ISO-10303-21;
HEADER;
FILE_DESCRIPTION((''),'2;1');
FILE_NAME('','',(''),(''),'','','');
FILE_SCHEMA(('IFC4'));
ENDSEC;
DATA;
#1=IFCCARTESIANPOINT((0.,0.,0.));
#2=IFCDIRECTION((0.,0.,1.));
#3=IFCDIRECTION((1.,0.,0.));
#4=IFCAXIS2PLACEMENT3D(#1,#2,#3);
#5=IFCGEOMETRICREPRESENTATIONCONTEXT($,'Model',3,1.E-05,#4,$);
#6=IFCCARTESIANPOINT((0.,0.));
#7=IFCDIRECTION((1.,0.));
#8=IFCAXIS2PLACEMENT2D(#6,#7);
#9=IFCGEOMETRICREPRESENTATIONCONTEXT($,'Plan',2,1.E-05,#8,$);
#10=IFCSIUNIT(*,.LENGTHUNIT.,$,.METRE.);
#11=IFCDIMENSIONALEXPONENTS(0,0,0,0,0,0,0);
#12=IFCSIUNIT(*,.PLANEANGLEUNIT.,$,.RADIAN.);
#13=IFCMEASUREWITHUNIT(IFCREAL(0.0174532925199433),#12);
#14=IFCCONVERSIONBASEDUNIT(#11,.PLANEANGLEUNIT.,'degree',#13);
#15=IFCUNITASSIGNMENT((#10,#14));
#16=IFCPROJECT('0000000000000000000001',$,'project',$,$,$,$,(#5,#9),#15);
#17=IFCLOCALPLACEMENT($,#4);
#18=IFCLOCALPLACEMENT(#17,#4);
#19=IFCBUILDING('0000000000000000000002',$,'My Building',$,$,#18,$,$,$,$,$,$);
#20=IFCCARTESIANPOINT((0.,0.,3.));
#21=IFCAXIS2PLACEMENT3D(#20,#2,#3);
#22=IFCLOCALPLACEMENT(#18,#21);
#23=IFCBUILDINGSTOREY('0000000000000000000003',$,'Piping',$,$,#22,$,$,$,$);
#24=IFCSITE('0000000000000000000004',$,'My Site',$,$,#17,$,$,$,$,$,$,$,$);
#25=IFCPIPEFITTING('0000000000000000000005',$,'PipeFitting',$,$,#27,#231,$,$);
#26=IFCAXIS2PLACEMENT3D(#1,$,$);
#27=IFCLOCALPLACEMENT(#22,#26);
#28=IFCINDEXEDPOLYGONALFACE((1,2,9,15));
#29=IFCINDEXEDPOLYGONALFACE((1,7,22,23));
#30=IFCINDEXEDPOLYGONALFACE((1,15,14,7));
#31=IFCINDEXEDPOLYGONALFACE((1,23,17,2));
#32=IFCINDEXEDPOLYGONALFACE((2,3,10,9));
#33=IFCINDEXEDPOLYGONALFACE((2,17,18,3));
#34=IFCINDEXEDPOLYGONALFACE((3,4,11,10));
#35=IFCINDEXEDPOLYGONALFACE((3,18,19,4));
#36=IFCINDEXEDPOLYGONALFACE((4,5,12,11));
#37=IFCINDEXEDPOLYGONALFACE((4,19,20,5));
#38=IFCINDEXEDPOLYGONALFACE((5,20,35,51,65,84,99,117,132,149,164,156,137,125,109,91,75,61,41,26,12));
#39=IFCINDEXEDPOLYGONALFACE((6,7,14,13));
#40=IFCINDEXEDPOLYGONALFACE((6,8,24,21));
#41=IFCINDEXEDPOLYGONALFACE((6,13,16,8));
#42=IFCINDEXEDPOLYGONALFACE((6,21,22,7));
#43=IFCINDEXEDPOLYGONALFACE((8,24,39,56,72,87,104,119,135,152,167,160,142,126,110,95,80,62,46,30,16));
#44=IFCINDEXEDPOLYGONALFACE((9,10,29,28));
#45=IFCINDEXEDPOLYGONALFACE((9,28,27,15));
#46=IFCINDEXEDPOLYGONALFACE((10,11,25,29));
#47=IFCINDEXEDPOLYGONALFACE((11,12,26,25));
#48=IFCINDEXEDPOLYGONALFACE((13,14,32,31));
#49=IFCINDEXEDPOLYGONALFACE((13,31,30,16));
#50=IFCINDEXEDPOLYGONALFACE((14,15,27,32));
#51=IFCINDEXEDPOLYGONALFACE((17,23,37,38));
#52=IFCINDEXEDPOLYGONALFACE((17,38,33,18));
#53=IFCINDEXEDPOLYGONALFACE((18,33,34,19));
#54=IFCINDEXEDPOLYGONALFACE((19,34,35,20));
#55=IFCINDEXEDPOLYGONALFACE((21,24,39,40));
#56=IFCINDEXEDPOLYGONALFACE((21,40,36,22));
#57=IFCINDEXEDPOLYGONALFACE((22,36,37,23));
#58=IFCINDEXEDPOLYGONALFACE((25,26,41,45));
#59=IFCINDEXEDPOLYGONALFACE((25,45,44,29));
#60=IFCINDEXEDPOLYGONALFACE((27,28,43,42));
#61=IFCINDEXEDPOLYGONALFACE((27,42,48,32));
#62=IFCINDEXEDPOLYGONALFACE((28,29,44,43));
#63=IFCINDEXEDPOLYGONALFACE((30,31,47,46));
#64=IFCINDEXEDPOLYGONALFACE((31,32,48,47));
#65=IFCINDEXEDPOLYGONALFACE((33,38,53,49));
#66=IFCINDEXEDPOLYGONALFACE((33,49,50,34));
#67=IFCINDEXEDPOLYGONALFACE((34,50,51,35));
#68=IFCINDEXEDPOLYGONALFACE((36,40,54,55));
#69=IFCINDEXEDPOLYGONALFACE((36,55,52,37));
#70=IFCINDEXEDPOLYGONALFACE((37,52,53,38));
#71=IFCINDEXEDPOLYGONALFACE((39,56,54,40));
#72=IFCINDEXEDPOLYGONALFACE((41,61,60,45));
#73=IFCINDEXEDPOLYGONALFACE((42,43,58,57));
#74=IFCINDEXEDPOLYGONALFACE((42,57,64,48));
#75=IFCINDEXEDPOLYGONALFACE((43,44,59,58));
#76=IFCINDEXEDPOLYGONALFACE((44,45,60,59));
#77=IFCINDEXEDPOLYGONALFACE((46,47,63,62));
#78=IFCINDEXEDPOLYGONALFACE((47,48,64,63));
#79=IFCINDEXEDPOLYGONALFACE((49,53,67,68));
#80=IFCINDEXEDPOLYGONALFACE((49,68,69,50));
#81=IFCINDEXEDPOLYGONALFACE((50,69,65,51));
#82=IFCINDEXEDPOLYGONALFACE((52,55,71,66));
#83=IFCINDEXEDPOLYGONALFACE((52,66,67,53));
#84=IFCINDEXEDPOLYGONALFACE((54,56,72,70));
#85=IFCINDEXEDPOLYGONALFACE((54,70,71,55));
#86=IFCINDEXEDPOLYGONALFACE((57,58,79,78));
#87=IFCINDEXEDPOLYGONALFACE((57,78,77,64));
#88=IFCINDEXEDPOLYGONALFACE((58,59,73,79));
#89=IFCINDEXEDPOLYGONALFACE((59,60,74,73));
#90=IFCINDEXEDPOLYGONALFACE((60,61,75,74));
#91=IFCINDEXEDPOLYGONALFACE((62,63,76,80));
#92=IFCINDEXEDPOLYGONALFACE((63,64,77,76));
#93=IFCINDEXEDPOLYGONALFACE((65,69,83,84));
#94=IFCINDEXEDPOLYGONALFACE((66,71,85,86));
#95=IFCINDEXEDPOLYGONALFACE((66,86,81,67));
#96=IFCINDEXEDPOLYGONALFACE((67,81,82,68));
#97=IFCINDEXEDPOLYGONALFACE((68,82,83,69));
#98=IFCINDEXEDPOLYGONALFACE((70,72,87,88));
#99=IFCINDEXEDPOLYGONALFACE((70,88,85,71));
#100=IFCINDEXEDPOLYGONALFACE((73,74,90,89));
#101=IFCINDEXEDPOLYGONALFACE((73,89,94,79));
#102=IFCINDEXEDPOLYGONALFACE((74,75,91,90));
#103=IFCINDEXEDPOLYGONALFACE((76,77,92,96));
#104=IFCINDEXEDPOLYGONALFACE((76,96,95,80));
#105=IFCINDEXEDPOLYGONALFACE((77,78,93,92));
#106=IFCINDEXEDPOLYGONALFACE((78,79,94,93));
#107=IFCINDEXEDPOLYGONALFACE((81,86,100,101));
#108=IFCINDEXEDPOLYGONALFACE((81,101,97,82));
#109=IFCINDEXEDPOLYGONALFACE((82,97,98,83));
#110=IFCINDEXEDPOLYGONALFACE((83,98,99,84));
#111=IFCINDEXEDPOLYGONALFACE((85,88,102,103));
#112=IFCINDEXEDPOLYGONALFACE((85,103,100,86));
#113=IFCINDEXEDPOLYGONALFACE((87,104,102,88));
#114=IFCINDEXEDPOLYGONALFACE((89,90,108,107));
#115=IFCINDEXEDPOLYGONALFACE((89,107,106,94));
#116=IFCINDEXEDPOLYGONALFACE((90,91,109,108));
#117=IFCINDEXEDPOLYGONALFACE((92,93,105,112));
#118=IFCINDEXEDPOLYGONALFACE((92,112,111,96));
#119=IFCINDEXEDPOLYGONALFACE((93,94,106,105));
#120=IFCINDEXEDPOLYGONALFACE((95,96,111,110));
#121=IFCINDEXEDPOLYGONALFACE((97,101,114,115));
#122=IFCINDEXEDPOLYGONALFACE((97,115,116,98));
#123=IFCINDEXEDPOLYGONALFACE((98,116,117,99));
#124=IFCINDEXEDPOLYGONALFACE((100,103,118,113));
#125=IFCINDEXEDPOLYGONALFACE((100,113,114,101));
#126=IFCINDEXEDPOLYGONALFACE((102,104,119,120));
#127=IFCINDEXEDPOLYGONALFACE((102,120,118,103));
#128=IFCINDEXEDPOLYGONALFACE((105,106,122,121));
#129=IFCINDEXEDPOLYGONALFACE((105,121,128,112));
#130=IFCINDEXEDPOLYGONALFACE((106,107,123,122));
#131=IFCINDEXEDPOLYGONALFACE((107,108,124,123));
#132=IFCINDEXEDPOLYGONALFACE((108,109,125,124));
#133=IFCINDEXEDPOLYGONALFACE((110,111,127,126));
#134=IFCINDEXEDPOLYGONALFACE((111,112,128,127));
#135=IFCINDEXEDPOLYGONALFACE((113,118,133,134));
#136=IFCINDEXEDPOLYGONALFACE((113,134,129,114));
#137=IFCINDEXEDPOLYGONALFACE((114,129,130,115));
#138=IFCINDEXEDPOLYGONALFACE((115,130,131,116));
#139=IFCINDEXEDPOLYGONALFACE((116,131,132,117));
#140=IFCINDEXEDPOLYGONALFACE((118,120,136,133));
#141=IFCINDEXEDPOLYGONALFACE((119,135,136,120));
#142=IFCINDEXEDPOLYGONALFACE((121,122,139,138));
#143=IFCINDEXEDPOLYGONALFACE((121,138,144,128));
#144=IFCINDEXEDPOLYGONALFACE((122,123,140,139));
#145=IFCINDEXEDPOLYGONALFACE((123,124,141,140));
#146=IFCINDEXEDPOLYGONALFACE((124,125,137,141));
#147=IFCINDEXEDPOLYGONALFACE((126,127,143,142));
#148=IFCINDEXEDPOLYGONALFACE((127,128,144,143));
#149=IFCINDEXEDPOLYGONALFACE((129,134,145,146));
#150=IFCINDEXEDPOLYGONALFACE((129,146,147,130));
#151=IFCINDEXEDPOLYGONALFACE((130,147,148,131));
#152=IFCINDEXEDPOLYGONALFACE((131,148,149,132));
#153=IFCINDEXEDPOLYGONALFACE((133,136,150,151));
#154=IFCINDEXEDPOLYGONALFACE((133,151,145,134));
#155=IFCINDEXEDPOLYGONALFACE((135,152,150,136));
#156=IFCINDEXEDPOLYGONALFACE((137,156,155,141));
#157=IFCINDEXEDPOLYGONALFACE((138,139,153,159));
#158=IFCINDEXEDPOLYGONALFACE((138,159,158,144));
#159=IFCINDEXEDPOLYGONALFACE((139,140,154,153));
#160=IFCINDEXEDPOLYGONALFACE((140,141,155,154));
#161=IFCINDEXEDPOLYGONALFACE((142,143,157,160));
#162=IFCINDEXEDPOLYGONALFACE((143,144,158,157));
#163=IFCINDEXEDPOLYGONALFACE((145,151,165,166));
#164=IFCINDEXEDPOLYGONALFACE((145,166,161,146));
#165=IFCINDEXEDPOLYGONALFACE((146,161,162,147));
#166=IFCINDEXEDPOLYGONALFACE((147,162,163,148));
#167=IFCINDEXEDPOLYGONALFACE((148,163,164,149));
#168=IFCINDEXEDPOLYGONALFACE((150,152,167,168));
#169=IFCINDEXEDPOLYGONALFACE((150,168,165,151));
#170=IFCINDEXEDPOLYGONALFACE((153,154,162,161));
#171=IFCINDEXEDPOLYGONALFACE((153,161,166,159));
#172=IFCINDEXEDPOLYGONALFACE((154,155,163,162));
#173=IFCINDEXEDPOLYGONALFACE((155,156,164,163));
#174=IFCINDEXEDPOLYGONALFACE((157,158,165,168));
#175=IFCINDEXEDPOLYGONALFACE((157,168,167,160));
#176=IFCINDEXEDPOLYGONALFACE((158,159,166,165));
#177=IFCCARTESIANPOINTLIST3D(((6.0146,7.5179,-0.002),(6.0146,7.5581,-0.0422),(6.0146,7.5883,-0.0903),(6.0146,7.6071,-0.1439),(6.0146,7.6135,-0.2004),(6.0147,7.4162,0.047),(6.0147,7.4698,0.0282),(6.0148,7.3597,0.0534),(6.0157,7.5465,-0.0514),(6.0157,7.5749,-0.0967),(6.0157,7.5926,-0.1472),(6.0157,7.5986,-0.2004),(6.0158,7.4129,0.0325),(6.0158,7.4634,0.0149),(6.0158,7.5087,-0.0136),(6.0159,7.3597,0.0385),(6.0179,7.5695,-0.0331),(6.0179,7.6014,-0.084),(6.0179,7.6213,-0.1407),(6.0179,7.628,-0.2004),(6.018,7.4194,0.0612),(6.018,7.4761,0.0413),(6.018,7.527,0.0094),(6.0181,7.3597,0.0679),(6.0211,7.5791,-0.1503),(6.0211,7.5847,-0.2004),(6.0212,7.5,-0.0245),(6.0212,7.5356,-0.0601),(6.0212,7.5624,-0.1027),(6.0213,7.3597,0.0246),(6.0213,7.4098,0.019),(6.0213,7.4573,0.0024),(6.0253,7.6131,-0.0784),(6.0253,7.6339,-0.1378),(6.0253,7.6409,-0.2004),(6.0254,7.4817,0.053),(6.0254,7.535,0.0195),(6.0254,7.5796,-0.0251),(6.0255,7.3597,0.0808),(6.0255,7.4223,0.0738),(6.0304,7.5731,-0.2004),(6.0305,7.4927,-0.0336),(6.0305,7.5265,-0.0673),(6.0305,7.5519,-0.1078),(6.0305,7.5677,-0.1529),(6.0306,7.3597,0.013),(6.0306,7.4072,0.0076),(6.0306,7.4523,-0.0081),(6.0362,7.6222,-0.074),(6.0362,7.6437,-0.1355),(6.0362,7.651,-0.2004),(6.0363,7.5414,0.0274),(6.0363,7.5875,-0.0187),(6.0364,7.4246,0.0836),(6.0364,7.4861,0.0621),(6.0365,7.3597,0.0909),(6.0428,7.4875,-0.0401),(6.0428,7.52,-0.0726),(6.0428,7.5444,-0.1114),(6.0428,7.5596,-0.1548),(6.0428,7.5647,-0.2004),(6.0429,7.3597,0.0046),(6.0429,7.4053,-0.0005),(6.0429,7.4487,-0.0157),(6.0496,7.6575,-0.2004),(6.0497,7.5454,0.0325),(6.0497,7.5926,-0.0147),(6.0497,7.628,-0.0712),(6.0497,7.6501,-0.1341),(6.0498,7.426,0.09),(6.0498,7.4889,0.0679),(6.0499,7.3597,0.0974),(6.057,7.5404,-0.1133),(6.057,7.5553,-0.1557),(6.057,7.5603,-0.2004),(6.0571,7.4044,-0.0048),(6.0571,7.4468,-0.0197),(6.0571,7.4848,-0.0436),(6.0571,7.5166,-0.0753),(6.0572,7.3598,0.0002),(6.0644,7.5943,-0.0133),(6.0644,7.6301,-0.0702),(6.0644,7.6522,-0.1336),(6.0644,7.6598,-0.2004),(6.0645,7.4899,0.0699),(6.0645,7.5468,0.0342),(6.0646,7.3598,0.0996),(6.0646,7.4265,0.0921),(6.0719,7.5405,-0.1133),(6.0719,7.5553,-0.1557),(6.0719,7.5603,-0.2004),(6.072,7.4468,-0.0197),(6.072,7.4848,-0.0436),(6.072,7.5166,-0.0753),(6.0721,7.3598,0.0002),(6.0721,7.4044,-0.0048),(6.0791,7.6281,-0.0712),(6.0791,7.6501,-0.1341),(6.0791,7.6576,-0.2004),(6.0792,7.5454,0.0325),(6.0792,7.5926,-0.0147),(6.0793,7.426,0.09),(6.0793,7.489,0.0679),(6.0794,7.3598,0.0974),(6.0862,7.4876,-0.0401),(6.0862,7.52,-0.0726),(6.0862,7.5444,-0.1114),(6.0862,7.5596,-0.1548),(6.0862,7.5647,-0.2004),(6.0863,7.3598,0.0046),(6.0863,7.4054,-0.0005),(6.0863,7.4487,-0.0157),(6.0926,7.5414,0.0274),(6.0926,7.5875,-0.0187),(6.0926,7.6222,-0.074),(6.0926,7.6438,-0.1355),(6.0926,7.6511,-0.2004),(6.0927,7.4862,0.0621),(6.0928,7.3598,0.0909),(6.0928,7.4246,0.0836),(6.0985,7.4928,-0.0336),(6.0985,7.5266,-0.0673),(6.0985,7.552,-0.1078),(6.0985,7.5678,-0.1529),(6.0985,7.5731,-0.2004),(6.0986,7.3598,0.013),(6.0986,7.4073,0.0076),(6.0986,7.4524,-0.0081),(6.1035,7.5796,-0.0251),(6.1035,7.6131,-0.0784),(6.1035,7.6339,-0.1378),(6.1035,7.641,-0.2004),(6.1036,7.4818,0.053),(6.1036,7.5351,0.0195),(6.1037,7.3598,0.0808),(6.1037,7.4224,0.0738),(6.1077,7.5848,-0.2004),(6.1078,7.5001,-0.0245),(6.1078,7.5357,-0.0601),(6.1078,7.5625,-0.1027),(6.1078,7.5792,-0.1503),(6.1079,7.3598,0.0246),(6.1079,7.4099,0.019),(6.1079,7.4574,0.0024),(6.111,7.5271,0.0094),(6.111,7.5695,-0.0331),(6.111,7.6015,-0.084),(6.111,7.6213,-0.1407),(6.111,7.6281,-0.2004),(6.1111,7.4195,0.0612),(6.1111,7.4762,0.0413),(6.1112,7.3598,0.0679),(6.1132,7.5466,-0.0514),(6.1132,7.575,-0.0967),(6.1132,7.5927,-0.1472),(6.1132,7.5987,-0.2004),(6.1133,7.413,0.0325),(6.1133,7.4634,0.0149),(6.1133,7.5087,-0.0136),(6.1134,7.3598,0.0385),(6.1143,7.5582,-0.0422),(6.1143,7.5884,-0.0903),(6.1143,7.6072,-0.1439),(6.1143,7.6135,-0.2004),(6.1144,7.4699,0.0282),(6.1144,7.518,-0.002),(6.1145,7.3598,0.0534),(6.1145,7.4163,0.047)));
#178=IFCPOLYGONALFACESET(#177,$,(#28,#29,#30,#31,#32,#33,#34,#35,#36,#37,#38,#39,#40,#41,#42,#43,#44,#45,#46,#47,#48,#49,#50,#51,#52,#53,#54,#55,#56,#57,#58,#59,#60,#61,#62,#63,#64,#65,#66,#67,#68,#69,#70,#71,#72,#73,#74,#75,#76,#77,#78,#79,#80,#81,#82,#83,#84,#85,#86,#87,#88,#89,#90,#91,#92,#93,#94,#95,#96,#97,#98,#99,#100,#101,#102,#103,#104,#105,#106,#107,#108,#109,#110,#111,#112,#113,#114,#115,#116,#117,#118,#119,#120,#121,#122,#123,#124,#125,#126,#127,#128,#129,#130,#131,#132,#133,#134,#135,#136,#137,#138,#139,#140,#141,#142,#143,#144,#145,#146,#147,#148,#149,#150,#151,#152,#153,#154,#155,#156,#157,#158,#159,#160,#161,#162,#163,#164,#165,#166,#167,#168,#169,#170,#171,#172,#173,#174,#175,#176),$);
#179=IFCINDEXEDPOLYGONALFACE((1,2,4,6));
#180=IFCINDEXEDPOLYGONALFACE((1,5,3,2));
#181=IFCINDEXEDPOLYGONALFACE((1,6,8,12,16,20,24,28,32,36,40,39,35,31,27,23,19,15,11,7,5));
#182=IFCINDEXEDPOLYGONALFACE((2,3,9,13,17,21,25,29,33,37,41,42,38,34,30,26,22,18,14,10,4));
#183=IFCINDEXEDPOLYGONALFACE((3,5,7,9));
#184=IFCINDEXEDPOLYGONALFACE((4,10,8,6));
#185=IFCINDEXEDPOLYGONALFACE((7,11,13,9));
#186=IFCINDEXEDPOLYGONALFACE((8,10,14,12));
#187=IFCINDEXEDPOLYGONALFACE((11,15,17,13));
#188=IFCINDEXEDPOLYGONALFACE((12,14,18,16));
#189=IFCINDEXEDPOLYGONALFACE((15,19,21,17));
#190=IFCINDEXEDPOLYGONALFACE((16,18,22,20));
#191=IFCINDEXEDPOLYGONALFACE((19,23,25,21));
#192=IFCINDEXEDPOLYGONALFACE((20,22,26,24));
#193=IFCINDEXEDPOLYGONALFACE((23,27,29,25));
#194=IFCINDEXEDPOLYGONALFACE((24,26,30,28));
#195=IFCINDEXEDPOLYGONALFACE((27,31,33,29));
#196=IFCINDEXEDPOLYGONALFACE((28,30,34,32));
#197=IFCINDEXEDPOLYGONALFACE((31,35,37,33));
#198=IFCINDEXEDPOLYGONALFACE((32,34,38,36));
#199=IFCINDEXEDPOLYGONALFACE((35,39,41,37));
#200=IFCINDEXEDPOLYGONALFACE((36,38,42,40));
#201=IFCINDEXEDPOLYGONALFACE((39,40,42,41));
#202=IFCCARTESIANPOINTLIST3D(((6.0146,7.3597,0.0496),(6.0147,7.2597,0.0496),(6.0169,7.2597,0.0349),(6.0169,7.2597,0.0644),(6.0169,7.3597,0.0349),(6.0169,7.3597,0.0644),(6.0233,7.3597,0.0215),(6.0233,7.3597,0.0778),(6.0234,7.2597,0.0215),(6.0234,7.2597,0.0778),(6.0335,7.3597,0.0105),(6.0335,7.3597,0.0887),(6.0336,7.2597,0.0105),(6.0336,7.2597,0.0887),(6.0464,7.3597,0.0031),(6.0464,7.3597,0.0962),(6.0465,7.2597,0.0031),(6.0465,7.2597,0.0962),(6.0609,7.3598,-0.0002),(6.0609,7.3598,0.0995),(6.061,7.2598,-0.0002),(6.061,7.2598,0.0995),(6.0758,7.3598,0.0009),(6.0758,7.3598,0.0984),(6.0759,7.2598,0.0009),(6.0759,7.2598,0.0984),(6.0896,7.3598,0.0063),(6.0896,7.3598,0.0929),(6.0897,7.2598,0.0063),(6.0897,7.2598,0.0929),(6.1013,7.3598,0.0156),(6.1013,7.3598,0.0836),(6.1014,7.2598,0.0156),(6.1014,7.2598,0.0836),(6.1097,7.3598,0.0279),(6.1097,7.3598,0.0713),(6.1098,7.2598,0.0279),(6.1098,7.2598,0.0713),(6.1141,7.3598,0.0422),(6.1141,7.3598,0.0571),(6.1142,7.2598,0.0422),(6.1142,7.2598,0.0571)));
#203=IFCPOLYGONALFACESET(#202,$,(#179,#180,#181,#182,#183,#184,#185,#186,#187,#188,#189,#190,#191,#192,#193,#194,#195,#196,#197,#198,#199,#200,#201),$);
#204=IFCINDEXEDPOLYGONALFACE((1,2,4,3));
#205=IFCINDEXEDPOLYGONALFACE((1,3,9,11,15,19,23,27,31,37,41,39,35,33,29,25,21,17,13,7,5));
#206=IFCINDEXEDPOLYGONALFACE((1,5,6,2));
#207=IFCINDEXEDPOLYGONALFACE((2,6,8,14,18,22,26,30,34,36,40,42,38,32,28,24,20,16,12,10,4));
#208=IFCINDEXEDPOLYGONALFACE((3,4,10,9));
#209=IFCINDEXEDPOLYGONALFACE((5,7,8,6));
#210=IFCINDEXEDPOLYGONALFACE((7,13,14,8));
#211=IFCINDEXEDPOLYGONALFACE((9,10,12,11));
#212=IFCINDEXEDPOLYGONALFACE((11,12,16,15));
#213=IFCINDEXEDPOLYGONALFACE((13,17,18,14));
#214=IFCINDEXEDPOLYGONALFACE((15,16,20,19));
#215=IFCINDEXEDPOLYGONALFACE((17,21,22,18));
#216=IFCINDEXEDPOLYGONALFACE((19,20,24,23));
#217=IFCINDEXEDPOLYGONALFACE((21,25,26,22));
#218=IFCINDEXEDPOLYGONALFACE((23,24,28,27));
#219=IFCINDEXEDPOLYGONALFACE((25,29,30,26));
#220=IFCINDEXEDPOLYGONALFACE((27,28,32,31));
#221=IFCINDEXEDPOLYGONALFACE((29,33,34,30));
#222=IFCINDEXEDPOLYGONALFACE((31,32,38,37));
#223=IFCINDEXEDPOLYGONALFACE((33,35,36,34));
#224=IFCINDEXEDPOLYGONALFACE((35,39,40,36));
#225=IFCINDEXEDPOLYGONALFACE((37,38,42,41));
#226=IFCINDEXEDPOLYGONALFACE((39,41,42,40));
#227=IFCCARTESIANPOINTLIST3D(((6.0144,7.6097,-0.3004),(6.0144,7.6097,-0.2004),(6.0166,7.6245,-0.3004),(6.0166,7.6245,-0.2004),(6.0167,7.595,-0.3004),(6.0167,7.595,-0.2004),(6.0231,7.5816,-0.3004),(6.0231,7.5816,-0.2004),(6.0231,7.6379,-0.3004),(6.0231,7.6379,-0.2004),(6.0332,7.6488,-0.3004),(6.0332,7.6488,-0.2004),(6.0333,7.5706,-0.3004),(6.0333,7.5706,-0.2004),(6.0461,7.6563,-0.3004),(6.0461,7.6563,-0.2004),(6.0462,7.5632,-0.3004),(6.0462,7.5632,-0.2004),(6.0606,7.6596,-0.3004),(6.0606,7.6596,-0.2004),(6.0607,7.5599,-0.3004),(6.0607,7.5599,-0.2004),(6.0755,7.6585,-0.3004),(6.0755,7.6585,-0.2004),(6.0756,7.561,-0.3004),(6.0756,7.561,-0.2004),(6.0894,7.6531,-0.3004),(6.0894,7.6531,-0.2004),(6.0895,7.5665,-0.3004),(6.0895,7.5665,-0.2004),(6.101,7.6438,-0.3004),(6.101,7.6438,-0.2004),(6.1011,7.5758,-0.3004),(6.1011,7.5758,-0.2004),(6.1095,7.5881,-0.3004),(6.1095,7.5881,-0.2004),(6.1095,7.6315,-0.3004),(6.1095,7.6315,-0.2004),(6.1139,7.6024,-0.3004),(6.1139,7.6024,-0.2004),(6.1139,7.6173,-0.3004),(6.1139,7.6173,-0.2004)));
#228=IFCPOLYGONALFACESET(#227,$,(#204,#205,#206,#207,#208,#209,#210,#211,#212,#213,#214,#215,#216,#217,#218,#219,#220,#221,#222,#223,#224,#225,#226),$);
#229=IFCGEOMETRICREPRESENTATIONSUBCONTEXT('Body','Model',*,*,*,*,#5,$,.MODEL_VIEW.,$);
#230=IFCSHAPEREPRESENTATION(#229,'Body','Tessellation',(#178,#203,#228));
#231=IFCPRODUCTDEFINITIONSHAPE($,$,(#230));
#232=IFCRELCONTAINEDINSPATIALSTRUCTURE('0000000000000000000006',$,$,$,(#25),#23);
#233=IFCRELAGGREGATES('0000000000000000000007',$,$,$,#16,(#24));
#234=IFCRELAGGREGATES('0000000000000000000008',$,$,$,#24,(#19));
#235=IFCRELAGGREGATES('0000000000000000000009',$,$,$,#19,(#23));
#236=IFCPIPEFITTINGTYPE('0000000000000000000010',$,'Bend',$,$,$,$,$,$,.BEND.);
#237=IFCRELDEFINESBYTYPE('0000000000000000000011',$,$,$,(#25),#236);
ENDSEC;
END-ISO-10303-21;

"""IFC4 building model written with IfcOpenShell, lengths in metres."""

from ifc_helpers import new_model, entity, si_unit, converted_unit, frame, origin_with_axes, origin_2d_with_axis, place, context, subcontext, project, spatial, circle, extrude, source, transform, mapped, type_object, type_shapes, element, save


model = new_model("IFC4")

# Units and contexts
model_context = context("Model", 3, precision=1e-05, world=origin_with_axes())
plan_context = context("Plan", 2, precision=1e-05, world=origin_2d_with_axis())
body_context = subcontext(model_context, "Body", "Model", "MODEL_VIEW")
ifc_project = project(units=[si_unit("LENGTHUNIT", "METRE"), converted_unit("PLANEANGLEUNIT", "degree", entity("IfcReal", 0.0174532925199433), si_unit("PLANEANGLEUNIT", "RADIAN"), dimensions=[0, 0, 0, 0, 0, 0, 0])], contexts=[model_context, plan_context])

# Site, building, storey
site_placement = place(None, origin_with_axes())
site = spatial("IfcSite", under=ifc_project, at=site_placement, Name="My Site")
building_placement = place(site_placement, origin_with_axes())
building = spatial("IfcBuilding", under=site, at=building_placement, Name="My Building")
storey_placement = place(building_placement, frame((0.0, 0.0, 3.0), z_axis=(0.0, 0.0, 1.0), x_axis=(1.0, 0.0, 0.0)))
storey = spatial("IfcBuildingStorey", under=building, at=storey_placement, Name="Piping")

# Pipe fitting
pipe_fitting_type_1 = type_object("IfcPipeFittingType", Name="Bend", PredefinedType="BEND")
shared_shape = source(origin_with_axes(), body_context, "Body", "SolidModel", [
    entity("IfcSweptDiskSolid", entity("IfcIndexedPolyCurve", entity("IfcCartesianPointList3D", [[0.0, 0.0, 0.1], [0.0, -0.0732, 0.2768], [0.0, -0.25, 0.35]]), [entity("IfcArcIndex", [1, 2, 3])]), 0.05),
    extrude(circle(Radius=0.05), origin_with_axes(), (0.0, 0.0, 1.0), 0.1),
    extrude(circle(Radius=0.05), frame((0.0, -0.25, 0.35), z_axis=(0.0, -1.0, -0.000001), x_axis=(1.0, 0.0, 0.0)), (0.0, 0.0, 1.0), 0.1),
])
type_shapes(pipe_fitting_type_1, [shared_shape])
for number, where, z_axis, x_axis, name in (
    (1, (6.0647, 7.2598, 0.0496), (-0.000872, 1.0, 0.000001), (-1.0, -0.000872, 0.0), "PipeFitting"),
):
    element("IfcPipeFitting", number, at=place(storey_placement, frame(where, z_axis=z_axis, x_axis=x_axis)), inside=storey, type_object=pipe_fitting_type_1, Name=name, context=body_context, shape_type="MappedRepresentation", body=[
        mapped(shared_shape, transform((0.0, 0.0, 0.0), x_axis=(1.0, 0.0, 0.0), y_axis=(0.0, 1.0, 0.0), z_axis=(0.0, 0.0, 1.0), scale=1.0)),
    ])

save(model, "model.ifc")
